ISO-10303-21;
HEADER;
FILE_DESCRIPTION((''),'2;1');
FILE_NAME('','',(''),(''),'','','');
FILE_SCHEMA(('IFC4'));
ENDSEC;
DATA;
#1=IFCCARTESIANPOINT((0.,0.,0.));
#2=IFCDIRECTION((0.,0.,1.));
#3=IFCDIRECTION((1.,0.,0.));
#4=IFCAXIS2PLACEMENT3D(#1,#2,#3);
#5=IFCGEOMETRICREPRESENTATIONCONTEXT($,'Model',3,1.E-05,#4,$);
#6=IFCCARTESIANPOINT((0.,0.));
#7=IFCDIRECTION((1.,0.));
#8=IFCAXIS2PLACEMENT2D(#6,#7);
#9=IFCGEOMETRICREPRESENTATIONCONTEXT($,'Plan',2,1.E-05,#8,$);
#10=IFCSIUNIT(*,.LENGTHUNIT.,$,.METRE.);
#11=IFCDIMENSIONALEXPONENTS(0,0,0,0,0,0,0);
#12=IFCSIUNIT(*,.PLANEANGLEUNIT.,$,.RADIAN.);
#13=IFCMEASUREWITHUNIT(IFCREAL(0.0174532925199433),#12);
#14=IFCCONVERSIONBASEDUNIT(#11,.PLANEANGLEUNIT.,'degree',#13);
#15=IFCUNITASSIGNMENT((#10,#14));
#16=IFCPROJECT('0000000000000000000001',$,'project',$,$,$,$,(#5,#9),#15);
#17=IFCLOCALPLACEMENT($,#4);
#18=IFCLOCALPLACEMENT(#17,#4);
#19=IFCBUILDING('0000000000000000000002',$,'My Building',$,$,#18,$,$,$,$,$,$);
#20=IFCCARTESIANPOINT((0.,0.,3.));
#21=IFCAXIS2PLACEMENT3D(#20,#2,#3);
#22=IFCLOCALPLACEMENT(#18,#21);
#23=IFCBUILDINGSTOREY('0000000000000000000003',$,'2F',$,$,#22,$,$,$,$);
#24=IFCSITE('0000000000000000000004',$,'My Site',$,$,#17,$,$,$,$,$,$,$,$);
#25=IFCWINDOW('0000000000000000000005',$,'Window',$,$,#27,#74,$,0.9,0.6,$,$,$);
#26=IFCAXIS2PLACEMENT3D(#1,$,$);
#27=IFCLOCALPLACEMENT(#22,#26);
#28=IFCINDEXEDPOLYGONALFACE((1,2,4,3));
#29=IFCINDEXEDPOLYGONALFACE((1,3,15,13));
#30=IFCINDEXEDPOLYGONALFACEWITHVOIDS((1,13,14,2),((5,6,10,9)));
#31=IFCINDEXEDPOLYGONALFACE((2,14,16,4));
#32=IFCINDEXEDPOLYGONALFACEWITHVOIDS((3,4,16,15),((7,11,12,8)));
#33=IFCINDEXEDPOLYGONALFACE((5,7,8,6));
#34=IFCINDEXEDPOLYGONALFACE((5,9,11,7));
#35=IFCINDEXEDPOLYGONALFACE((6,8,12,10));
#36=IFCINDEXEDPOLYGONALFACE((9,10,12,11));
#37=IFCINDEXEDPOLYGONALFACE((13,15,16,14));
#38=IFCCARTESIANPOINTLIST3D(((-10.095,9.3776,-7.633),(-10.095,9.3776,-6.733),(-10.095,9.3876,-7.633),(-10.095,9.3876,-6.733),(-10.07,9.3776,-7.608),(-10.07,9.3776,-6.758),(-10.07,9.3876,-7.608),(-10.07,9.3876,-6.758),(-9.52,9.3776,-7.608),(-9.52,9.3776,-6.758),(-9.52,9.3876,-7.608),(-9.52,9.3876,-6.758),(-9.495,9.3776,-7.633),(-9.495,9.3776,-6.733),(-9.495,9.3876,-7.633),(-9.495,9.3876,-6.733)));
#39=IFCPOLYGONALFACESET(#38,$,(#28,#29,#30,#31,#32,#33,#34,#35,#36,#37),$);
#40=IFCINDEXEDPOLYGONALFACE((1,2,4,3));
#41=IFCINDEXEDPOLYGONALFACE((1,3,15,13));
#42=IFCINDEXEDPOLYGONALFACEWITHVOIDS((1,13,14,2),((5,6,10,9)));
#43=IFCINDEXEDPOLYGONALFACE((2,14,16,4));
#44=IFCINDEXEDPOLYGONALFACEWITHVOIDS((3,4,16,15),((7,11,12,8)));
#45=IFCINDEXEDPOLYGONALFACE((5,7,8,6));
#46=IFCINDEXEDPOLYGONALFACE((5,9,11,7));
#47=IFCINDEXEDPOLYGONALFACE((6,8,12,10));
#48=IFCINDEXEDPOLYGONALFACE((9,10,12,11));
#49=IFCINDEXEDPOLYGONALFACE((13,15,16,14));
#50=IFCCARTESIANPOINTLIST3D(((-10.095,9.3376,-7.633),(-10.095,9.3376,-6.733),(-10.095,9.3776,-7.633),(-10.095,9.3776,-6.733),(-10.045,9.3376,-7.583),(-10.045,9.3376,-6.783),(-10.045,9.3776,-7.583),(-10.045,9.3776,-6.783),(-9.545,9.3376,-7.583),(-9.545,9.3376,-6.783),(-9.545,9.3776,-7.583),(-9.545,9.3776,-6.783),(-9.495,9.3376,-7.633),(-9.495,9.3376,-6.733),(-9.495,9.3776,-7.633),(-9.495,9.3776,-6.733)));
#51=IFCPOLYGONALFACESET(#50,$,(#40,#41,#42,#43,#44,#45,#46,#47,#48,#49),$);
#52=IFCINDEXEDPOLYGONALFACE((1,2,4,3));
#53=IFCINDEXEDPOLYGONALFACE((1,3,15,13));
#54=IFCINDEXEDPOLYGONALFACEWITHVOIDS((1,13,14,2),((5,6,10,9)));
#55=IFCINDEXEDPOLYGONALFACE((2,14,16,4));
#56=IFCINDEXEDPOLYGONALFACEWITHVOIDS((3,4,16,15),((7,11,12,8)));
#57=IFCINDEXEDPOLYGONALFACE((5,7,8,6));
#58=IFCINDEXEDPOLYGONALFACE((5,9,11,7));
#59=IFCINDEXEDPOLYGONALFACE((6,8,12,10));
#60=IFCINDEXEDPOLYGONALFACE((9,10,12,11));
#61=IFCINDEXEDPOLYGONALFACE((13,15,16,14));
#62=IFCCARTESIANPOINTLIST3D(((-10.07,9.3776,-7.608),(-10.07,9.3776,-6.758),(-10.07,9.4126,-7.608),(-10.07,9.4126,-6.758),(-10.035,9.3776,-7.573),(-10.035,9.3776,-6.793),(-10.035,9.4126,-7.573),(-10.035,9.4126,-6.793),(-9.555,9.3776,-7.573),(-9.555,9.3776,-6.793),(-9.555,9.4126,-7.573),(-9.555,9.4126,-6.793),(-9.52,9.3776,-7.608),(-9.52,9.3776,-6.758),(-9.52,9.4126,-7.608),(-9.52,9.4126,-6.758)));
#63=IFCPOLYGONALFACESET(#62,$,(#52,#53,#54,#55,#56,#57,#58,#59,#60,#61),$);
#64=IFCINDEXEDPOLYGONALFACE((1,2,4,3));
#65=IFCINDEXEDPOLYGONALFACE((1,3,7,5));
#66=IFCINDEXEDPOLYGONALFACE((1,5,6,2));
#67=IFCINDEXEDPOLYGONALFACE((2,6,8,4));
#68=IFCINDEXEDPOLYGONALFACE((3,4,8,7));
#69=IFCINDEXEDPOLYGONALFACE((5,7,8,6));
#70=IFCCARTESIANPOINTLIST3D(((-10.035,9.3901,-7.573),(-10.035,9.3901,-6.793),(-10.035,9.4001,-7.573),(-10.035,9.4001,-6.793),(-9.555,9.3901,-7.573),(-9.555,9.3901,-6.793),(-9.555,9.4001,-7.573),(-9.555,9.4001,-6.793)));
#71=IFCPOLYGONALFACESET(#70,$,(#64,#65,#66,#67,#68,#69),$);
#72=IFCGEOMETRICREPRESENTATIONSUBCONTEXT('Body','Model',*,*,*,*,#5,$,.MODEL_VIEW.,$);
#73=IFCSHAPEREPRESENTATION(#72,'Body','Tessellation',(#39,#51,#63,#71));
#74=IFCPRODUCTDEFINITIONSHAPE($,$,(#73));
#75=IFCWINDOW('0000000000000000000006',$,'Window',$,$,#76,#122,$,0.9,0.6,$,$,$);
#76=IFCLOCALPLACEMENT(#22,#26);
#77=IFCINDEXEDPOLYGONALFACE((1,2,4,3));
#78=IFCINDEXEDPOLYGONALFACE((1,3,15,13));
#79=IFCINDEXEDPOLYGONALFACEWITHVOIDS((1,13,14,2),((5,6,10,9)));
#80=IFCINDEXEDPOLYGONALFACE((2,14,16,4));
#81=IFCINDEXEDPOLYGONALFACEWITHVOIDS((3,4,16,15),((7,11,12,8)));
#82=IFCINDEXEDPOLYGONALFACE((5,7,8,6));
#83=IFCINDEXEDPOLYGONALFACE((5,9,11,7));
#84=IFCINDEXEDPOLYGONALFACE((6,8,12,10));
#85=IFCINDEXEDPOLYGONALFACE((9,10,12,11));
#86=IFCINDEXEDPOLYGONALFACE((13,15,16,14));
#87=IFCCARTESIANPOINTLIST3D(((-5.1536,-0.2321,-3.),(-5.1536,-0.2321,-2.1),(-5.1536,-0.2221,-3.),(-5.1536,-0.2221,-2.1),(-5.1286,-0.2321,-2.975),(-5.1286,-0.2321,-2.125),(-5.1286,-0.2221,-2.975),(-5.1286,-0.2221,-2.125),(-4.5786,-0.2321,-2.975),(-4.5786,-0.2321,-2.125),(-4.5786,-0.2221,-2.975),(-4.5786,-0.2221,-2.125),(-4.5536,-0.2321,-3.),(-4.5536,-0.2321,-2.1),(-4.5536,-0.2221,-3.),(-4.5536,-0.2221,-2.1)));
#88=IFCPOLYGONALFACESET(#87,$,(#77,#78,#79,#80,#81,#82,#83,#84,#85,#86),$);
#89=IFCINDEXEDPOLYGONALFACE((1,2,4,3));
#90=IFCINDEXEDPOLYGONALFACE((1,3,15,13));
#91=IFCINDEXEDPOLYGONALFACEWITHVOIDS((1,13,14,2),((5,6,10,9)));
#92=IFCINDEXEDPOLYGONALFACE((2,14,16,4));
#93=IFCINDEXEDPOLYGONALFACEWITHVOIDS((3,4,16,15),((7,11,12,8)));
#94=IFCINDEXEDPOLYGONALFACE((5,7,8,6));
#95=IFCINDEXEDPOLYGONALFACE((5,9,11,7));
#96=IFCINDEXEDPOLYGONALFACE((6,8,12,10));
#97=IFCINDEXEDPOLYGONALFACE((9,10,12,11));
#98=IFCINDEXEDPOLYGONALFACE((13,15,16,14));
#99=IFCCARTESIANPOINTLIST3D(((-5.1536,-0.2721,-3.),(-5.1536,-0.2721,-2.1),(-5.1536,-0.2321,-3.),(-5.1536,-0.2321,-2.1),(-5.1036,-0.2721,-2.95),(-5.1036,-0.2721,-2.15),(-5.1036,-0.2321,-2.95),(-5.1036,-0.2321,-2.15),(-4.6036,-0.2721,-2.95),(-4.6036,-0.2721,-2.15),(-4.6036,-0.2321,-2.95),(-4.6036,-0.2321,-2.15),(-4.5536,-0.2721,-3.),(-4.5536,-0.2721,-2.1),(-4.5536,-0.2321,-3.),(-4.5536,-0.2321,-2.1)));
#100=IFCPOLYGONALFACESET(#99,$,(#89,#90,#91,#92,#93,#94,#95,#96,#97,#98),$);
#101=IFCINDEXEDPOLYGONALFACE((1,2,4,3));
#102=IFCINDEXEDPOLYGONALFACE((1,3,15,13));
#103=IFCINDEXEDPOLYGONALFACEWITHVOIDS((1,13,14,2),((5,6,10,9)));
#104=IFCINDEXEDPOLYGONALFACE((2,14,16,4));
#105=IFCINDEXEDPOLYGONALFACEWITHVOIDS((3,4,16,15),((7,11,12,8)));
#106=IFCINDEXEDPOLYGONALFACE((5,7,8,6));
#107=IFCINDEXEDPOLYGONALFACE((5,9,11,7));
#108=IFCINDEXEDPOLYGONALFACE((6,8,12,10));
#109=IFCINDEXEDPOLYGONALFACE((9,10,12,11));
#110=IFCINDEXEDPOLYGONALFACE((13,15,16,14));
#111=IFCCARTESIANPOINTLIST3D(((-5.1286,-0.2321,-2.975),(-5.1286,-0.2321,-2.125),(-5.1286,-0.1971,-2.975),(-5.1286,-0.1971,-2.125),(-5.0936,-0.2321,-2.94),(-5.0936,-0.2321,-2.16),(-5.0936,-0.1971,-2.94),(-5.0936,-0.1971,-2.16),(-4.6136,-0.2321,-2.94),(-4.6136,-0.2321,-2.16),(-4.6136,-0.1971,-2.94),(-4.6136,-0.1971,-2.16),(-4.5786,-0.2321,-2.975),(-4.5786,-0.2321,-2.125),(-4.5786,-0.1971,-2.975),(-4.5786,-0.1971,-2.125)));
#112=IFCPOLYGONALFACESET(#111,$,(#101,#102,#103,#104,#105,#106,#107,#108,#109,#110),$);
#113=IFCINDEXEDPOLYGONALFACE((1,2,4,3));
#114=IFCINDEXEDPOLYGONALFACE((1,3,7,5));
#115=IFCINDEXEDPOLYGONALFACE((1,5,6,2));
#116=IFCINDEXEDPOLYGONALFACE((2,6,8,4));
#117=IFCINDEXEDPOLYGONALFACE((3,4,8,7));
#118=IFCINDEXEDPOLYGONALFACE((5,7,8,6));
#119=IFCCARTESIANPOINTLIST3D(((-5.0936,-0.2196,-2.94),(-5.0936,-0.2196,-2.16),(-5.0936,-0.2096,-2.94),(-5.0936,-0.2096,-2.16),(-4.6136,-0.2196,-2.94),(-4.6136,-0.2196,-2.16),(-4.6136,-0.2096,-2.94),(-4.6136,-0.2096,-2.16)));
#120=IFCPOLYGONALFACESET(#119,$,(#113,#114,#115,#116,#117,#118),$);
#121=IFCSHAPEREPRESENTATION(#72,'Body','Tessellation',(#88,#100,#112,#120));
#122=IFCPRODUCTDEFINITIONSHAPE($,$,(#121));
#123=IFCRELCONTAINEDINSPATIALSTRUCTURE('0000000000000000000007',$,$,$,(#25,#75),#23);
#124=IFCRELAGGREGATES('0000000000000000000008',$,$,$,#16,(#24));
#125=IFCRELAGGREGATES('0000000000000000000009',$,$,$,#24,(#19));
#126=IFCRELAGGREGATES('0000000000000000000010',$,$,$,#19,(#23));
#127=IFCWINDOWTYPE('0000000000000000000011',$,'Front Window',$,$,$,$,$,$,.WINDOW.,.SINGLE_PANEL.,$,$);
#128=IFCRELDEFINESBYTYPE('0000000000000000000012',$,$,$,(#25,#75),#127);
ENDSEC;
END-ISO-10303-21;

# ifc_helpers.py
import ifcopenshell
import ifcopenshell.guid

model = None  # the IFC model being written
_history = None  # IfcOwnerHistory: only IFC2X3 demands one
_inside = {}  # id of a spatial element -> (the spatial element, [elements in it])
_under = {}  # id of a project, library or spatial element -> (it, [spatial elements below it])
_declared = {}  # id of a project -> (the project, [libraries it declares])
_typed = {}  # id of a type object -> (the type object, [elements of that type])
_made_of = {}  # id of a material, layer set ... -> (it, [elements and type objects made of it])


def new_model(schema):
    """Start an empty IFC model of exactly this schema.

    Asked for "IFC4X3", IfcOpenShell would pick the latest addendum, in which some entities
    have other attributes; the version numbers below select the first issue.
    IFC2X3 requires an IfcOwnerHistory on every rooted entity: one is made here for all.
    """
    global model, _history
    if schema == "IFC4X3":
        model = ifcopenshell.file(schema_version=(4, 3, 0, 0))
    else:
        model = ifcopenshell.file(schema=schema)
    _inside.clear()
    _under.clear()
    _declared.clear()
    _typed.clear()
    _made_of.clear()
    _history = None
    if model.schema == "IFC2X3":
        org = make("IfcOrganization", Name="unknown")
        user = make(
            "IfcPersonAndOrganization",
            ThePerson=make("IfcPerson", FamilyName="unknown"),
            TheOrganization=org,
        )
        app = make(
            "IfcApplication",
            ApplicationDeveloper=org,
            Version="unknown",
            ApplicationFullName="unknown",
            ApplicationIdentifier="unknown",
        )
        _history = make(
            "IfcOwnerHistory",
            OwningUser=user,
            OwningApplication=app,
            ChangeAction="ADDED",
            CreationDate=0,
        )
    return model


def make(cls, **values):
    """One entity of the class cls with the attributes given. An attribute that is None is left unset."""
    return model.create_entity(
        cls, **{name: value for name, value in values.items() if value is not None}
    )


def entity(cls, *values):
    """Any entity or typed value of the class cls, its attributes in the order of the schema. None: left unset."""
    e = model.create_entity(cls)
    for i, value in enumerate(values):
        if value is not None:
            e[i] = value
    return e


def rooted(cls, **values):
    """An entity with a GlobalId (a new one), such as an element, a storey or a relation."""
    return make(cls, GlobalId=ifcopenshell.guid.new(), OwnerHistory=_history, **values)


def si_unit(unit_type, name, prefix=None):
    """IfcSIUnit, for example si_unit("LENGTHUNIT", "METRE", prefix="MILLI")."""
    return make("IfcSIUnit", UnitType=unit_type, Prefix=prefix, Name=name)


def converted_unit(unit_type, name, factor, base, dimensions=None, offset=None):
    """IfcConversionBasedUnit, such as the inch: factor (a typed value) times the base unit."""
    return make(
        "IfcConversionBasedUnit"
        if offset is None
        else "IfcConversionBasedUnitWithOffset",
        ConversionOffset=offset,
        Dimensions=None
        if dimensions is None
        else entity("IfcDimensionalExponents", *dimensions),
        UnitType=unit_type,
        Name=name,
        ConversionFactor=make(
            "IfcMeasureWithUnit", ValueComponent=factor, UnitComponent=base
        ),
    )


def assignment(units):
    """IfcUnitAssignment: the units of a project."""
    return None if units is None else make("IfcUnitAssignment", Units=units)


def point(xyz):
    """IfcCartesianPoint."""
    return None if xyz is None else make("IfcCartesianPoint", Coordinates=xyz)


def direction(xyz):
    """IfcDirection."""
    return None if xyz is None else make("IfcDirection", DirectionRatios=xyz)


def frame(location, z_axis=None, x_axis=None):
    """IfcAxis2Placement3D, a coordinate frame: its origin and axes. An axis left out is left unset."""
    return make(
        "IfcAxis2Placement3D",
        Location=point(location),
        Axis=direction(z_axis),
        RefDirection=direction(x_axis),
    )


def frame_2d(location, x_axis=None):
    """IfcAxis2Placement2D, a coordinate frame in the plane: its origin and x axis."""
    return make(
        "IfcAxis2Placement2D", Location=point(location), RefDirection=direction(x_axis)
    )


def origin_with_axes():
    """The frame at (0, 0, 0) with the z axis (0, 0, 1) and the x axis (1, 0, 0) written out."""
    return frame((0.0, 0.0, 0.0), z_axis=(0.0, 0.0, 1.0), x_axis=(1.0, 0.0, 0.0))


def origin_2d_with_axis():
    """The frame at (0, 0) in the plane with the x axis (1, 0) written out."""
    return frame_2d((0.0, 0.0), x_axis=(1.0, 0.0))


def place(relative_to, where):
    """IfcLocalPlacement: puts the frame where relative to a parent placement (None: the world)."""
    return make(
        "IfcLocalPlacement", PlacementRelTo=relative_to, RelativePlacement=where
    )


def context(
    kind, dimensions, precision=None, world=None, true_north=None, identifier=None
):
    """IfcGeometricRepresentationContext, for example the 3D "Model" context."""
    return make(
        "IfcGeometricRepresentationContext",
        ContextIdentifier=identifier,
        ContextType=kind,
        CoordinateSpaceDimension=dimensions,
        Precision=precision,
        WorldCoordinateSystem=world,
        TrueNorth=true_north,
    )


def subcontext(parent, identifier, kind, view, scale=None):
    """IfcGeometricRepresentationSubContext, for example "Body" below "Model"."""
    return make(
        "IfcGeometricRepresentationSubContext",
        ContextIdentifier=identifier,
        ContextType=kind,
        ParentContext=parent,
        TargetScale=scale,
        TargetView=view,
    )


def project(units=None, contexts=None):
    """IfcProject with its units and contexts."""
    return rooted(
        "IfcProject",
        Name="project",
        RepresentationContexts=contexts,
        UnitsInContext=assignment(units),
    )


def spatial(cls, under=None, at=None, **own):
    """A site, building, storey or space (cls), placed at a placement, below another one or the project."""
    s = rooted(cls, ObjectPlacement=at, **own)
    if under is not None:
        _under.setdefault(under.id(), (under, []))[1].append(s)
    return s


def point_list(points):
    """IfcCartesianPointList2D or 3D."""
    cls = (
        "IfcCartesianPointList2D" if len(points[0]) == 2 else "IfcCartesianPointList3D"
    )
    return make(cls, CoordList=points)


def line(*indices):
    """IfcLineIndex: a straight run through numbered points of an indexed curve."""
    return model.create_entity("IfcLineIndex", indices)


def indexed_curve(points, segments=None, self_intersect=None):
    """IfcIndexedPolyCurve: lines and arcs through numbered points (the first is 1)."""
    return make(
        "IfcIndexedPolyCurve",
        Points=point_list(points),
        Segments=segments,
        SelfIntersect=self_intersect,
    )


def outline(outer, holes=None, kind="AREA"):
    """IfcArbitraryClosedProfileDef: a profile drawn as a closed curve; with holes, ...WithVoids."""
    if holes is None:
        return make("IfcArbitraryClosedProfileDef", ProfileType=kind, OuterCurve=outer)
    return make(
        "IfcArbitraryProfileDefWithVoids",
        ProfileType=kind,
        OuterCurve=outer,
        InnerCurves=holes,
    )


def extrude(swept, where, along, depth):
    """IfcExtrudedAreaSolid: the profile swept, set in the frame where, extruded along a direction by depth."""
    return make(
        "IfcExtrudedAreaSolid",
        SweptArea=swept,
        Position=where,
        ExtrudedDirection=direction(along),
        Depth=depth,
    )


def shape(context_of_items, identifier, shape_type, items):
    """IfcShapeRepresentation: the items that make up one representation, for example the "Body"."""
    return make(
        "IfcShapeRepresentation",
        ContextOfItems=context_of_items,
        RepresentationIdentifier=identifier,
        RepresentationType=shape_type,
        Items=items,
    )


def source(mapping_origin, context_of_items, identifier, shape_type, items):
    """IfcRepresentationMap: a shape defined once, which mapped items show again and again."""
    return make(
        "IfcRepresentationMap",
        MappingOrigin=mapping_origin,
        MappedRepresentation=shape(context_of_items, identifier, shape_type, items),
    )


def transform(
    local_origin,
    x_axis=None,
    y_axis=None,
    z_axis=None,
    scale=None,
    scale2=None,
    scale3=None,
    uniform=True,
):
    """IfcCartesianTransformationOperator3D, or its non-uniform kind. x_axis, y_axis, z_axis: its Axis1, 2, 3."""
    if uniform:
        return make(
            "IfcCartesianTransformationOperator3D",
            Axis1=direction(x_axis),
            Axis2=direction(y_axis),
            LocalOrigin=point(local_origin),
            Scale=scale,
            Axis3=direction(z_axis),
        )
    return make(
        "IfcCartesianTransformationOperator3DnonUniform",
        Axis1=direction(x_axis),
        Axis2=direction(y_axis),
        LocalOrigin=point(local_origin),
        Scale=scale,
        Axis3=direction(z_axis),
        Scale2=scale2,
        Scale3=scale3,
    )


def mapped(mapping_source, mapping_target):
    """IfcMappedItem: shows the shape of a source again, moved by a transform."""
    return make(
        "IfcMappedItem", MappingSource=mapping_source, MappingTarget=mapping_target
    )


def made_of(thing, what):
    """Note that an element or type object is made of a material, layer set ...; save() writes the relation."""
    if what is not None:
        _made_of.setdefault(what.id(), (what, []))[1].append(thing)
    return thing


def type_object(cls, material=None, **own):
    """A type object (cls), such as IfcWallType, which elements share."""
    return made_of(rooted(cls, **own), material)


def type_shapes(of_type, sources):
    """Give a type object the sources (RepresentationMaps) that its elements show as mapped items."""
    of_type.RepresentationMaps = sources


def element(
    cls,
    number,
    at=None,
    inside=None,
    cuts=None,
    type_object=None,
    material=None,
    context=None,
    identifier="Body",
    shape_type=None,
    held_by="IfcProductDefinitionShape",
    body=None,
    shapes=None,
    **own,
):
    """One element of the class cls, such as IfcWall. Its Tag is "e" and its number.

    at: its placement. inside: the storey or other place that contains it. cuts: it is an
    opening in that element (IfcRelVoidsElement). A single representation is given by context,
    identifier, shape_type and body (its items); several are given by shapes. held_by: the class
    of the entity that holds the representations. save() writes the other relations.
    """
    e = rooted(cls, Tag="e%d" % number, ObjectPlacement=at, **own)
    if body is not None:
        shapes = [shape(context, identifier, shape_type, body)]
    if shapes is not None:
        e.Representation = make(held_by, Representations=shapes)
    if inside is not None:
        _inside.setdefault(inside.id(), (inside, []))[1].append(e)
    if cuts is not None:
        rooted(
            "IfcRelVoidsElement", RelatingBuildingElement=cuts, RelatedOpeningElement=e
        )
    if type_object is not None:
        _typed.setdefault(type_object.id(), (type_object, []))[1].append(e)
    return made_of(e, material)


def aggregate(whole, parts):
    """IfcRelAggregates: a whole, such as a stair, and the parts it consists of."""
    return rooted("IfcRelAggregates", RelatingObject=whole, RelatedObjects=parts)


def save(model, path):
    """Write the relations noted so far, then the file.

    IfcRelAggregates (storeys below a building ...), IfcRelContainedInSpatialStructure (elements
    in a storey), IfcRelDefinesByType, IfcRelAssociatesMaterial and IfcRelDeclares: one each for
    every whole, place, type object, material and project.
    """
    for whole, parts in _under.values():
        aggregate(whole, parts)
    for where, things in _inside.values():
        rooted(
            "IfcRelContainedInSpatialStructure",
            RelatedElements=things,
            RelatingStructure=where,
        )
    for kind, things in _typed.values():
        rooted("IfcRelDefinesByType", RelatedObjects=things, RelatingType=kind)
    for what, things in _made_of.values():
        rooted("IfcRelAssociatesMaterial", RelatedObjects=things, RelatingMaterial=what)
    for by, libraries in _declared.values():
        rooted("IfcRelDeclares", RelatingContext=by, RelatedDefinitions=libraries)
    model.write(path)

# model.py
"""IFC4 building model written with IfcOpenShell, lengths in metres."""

from ifc_helpers import new_model, entity, si_unit, converted_unit, frame, origin_with_axes, origin_2d_with_axis, place, context, subcontext, project, spatial, line, indexed_curve, outline, extrude, shape, source, transform, mapped, type_object, type_shapes, element, save


model = new_model("IFC4")

# Units and contexts
model_context = context("Model", 3, precision=1e-05, world=origin_with_axes())
plan_context = context("Plan", 2, precision=1e-05, world=origin_2d_with_axis())
body_context_1 = subcontext(model_context, "Body", "Model", "MODEL_VIEW")
body_context_2 = subcontext(plan_context, "Body", "Plan", "PLAN_VIEW")
ifc_project = project(units=[si_unit("LENGTHUNIT", "METRE"), converted_unit("PLANEANGLEUNIT", "degree", entity("IfcReal", 0.0174532925199433), si_unit("PLANEANGLEUNIT", "RADIAN"), dimensions=[0, 0, 0, 0, 0, 0, 0])], contexts=[model_context, plan_context])

# Site, building, storey
site_placement = place(None, origin_with_axes())
site = spatial("IfcSite", under=ifc_project, at=site_placement, Name="My Site")
building_placement = place(site_placement, origin_with_axes())
building = spatial("IfcBuilding", under=site, at=building_placement, Name="My Building")
storey_placement = place(building_placement, frame((0.0, 0.0, 3.0), z_axis=(0.0, 0.0, 1.0), x_axis=(1.0, 0.0, 0.0)))
storey = spatial("IfcBuildingStorey", under=building, at=storey_placement, Name="2F")

# Shared definitions
window_type_1 = type_object("IfcWindowType", Name="Front Window", PartitioningType="SINGLE_PANEL", PredefinedType="WINDOW")
shared_shape_1 = source(origin_with_axes(), body_context_1, "Body", "SweptSolid", [
    extrude(outline(indexed_curve([(0.0, 0.0), (0.6, 0.0), (0.6, 0.9), (0.0, 0.9)], segments=[line(1, 2, 3, 4, 1)]), holes=[indexed_curve([(0.025, 0.025), (0.575, 0.025), (0.575, 0.875), (0.025, 0.875)], segments=[line(1, 2, 3, 4, 1)])]), frame((0.0, 0.09, 0.0), z_axis=(0.0, -1.0, 0.0), x_axis=(1.0, 0.0, 0.0)), (0.0, 0.0, -1.0), 0.01),
    extrude(outline(indexed_curve([(0.0, 0.0), (0.6, 0.0), (0.6, 0.9), (0.0, 0.9)], segments=[line(1, 2, 3, 4, 1)]), holes=[indexed_curve([(0.05, 0.05), (0.55, 0.05), (0.55, 0.85), (0.05, 0.85)], segments=[line(1, 2, 3, 4, 1)])]), frame((0.0, 0.05, 0.0), z_axis=(0.0, -1.0, 0.0), x_axis=(1.0, 0.0, 0.0)), (0.0, 0.0, -1.0), 0.04),
    extrude(outline(indexed_curve([(0.0, 0.0), (0.55, 0.0), (0.55, 0.85), (0.0, 0.85)], segments=[line(1, 2, 3, 4, 1)]), holes=[indexed_curve([(0.035, 0.035), (0.515, 0.035), (0.515, 0.815), (0.035, 0.815)], segments=[line(1, 2, 3, 4, 1)])]), frame((0.025, 0.09, 0.025), z_axis=(0.0, -1.0, 0.0), x_axis=(1.0, 0.0, 0.0)), (0.0, 0.0, -1.0), 0.035),
    extrude(outline(indexed_curve([(0.035, 0.035), (0.515, 0.035), (0.515, 0.815), (0.035, 0.815)], segments=[line(1, 2, 3, 4, 1)])), frame((0.025, 0.1025, 0.025), z_axis=(0.0, -1.0, 0.0), x_axis=(1.0, 0.0, 0.0)), (0.0, 0.0, -1.0), 0.01),
])
shared_shape_2 = source(origin_with_axes(), body_context_2, "Body", "Curve2D", [
    entity("IfcIndexedPolyCurve", entity("IfcCartesianPointList2D", [[0.05, 0.05], [0.55, 0.05]])),
    entity("IfcIndexedPolyCurve", entity("IfcCartesianPointList2D", [[0.0, 0.1], [0.025, 0.1], [0.025, 0.09], [0.05, 0.09], [0.05, 0.05], [0.0, 0.05]]), [entity("IfcLineIndex", [1, 2, 3, 4, 5, 6, 1])]),
    entity("IfcIndexedPolyCurve", entity("IfcCartesianPointList2D", [[0.6, 0.1], [0.575, 0.1], [0.575, 0.09], [0.55, 0.09], [0.55, 0.05], [0.6, 0.05]]), [entity("IfcLineIndex", [1, 2, 3, 4, 5, 6, 1])]),
    entity("IfcIndexedPolyCurve", entity("IfcCartesianPointList2D", [[0.025, 0.09], [0.06, 0.09], [0.06, 0.125], [0.025, 0.125]]), [entity("IfcLineIndex", [1, 2, 3, 4, 1])]),
    entity("IfcIndexedPolyCurve", entity("IfcCartesianPointList2D", [[0.575, 0.09], [0.54, 0.09], [0.54, 0.125], [0.575, 0.125]]), [entity("IfcLineIndex", [1, 2, 3, 4, 1])]),
    entity("IfcIndexedPolyCurve", entity("IfcCartesianPointList2D", [[0.06, 0.09], [0.54, 0.09]])),
    entity("IfcIndexedPolyCurve", entity("IfcCartesianPointList2D", [[0.06, 0.125], [0.54, 0.125]])),
    entity("IfcIndexedPolyCurve", entity("IfcCartesianPointList2D", [[0.06, 0.1075], [0.54, 0.1075]])),
])
type_shapes(window_type_1, [shared_shape_1, shared_shape_2])

# Windows
for number, where, z_axis, x_axis, name in (
    (1, (-10.095, 9.2876, -7.633), (0.0, 0.0, 1.0), (1.0, 0.0, 0.0), "Window"),
    (2, (-5.1536, -0.3221, -3.0), (0.0, 0.0, 1.0), (1.0, 0.0, 0.0), "Window"),
):
    element("IfcWindow", number, at=place(storey_placement, frame(where, z_axis=z_axis, x_axis=x_axis)), inside=storey, type_object=window_type_1, Name=name, OverallHeight=0.9, OverallWidth=0.6, shapes=[
        shape(body_context_1, "Body", "MappedRepresentation", [mapped(shared_shape_1, transform((0.0, 0.0, 0.0), x_axis=(1.0, 0.0, 0.0), y_axis=(0.0, 1.0, 0.0), z_axis=(0.0, 0.0, 1.0), scale=1.0))]),
        shape(body_context_2, "Body", "MappedRepresentation", [mapped(shared_shape_2, transform((0.0, 0.0, 0.0), x_axis=(1.0, 0.0, 0.0), y_axis=(0.0, 1.0, 0.0), z_axis=(0.0, 0.0, 1.0), scale=1.0))]),
    ])

save(model, "model.ifc")
